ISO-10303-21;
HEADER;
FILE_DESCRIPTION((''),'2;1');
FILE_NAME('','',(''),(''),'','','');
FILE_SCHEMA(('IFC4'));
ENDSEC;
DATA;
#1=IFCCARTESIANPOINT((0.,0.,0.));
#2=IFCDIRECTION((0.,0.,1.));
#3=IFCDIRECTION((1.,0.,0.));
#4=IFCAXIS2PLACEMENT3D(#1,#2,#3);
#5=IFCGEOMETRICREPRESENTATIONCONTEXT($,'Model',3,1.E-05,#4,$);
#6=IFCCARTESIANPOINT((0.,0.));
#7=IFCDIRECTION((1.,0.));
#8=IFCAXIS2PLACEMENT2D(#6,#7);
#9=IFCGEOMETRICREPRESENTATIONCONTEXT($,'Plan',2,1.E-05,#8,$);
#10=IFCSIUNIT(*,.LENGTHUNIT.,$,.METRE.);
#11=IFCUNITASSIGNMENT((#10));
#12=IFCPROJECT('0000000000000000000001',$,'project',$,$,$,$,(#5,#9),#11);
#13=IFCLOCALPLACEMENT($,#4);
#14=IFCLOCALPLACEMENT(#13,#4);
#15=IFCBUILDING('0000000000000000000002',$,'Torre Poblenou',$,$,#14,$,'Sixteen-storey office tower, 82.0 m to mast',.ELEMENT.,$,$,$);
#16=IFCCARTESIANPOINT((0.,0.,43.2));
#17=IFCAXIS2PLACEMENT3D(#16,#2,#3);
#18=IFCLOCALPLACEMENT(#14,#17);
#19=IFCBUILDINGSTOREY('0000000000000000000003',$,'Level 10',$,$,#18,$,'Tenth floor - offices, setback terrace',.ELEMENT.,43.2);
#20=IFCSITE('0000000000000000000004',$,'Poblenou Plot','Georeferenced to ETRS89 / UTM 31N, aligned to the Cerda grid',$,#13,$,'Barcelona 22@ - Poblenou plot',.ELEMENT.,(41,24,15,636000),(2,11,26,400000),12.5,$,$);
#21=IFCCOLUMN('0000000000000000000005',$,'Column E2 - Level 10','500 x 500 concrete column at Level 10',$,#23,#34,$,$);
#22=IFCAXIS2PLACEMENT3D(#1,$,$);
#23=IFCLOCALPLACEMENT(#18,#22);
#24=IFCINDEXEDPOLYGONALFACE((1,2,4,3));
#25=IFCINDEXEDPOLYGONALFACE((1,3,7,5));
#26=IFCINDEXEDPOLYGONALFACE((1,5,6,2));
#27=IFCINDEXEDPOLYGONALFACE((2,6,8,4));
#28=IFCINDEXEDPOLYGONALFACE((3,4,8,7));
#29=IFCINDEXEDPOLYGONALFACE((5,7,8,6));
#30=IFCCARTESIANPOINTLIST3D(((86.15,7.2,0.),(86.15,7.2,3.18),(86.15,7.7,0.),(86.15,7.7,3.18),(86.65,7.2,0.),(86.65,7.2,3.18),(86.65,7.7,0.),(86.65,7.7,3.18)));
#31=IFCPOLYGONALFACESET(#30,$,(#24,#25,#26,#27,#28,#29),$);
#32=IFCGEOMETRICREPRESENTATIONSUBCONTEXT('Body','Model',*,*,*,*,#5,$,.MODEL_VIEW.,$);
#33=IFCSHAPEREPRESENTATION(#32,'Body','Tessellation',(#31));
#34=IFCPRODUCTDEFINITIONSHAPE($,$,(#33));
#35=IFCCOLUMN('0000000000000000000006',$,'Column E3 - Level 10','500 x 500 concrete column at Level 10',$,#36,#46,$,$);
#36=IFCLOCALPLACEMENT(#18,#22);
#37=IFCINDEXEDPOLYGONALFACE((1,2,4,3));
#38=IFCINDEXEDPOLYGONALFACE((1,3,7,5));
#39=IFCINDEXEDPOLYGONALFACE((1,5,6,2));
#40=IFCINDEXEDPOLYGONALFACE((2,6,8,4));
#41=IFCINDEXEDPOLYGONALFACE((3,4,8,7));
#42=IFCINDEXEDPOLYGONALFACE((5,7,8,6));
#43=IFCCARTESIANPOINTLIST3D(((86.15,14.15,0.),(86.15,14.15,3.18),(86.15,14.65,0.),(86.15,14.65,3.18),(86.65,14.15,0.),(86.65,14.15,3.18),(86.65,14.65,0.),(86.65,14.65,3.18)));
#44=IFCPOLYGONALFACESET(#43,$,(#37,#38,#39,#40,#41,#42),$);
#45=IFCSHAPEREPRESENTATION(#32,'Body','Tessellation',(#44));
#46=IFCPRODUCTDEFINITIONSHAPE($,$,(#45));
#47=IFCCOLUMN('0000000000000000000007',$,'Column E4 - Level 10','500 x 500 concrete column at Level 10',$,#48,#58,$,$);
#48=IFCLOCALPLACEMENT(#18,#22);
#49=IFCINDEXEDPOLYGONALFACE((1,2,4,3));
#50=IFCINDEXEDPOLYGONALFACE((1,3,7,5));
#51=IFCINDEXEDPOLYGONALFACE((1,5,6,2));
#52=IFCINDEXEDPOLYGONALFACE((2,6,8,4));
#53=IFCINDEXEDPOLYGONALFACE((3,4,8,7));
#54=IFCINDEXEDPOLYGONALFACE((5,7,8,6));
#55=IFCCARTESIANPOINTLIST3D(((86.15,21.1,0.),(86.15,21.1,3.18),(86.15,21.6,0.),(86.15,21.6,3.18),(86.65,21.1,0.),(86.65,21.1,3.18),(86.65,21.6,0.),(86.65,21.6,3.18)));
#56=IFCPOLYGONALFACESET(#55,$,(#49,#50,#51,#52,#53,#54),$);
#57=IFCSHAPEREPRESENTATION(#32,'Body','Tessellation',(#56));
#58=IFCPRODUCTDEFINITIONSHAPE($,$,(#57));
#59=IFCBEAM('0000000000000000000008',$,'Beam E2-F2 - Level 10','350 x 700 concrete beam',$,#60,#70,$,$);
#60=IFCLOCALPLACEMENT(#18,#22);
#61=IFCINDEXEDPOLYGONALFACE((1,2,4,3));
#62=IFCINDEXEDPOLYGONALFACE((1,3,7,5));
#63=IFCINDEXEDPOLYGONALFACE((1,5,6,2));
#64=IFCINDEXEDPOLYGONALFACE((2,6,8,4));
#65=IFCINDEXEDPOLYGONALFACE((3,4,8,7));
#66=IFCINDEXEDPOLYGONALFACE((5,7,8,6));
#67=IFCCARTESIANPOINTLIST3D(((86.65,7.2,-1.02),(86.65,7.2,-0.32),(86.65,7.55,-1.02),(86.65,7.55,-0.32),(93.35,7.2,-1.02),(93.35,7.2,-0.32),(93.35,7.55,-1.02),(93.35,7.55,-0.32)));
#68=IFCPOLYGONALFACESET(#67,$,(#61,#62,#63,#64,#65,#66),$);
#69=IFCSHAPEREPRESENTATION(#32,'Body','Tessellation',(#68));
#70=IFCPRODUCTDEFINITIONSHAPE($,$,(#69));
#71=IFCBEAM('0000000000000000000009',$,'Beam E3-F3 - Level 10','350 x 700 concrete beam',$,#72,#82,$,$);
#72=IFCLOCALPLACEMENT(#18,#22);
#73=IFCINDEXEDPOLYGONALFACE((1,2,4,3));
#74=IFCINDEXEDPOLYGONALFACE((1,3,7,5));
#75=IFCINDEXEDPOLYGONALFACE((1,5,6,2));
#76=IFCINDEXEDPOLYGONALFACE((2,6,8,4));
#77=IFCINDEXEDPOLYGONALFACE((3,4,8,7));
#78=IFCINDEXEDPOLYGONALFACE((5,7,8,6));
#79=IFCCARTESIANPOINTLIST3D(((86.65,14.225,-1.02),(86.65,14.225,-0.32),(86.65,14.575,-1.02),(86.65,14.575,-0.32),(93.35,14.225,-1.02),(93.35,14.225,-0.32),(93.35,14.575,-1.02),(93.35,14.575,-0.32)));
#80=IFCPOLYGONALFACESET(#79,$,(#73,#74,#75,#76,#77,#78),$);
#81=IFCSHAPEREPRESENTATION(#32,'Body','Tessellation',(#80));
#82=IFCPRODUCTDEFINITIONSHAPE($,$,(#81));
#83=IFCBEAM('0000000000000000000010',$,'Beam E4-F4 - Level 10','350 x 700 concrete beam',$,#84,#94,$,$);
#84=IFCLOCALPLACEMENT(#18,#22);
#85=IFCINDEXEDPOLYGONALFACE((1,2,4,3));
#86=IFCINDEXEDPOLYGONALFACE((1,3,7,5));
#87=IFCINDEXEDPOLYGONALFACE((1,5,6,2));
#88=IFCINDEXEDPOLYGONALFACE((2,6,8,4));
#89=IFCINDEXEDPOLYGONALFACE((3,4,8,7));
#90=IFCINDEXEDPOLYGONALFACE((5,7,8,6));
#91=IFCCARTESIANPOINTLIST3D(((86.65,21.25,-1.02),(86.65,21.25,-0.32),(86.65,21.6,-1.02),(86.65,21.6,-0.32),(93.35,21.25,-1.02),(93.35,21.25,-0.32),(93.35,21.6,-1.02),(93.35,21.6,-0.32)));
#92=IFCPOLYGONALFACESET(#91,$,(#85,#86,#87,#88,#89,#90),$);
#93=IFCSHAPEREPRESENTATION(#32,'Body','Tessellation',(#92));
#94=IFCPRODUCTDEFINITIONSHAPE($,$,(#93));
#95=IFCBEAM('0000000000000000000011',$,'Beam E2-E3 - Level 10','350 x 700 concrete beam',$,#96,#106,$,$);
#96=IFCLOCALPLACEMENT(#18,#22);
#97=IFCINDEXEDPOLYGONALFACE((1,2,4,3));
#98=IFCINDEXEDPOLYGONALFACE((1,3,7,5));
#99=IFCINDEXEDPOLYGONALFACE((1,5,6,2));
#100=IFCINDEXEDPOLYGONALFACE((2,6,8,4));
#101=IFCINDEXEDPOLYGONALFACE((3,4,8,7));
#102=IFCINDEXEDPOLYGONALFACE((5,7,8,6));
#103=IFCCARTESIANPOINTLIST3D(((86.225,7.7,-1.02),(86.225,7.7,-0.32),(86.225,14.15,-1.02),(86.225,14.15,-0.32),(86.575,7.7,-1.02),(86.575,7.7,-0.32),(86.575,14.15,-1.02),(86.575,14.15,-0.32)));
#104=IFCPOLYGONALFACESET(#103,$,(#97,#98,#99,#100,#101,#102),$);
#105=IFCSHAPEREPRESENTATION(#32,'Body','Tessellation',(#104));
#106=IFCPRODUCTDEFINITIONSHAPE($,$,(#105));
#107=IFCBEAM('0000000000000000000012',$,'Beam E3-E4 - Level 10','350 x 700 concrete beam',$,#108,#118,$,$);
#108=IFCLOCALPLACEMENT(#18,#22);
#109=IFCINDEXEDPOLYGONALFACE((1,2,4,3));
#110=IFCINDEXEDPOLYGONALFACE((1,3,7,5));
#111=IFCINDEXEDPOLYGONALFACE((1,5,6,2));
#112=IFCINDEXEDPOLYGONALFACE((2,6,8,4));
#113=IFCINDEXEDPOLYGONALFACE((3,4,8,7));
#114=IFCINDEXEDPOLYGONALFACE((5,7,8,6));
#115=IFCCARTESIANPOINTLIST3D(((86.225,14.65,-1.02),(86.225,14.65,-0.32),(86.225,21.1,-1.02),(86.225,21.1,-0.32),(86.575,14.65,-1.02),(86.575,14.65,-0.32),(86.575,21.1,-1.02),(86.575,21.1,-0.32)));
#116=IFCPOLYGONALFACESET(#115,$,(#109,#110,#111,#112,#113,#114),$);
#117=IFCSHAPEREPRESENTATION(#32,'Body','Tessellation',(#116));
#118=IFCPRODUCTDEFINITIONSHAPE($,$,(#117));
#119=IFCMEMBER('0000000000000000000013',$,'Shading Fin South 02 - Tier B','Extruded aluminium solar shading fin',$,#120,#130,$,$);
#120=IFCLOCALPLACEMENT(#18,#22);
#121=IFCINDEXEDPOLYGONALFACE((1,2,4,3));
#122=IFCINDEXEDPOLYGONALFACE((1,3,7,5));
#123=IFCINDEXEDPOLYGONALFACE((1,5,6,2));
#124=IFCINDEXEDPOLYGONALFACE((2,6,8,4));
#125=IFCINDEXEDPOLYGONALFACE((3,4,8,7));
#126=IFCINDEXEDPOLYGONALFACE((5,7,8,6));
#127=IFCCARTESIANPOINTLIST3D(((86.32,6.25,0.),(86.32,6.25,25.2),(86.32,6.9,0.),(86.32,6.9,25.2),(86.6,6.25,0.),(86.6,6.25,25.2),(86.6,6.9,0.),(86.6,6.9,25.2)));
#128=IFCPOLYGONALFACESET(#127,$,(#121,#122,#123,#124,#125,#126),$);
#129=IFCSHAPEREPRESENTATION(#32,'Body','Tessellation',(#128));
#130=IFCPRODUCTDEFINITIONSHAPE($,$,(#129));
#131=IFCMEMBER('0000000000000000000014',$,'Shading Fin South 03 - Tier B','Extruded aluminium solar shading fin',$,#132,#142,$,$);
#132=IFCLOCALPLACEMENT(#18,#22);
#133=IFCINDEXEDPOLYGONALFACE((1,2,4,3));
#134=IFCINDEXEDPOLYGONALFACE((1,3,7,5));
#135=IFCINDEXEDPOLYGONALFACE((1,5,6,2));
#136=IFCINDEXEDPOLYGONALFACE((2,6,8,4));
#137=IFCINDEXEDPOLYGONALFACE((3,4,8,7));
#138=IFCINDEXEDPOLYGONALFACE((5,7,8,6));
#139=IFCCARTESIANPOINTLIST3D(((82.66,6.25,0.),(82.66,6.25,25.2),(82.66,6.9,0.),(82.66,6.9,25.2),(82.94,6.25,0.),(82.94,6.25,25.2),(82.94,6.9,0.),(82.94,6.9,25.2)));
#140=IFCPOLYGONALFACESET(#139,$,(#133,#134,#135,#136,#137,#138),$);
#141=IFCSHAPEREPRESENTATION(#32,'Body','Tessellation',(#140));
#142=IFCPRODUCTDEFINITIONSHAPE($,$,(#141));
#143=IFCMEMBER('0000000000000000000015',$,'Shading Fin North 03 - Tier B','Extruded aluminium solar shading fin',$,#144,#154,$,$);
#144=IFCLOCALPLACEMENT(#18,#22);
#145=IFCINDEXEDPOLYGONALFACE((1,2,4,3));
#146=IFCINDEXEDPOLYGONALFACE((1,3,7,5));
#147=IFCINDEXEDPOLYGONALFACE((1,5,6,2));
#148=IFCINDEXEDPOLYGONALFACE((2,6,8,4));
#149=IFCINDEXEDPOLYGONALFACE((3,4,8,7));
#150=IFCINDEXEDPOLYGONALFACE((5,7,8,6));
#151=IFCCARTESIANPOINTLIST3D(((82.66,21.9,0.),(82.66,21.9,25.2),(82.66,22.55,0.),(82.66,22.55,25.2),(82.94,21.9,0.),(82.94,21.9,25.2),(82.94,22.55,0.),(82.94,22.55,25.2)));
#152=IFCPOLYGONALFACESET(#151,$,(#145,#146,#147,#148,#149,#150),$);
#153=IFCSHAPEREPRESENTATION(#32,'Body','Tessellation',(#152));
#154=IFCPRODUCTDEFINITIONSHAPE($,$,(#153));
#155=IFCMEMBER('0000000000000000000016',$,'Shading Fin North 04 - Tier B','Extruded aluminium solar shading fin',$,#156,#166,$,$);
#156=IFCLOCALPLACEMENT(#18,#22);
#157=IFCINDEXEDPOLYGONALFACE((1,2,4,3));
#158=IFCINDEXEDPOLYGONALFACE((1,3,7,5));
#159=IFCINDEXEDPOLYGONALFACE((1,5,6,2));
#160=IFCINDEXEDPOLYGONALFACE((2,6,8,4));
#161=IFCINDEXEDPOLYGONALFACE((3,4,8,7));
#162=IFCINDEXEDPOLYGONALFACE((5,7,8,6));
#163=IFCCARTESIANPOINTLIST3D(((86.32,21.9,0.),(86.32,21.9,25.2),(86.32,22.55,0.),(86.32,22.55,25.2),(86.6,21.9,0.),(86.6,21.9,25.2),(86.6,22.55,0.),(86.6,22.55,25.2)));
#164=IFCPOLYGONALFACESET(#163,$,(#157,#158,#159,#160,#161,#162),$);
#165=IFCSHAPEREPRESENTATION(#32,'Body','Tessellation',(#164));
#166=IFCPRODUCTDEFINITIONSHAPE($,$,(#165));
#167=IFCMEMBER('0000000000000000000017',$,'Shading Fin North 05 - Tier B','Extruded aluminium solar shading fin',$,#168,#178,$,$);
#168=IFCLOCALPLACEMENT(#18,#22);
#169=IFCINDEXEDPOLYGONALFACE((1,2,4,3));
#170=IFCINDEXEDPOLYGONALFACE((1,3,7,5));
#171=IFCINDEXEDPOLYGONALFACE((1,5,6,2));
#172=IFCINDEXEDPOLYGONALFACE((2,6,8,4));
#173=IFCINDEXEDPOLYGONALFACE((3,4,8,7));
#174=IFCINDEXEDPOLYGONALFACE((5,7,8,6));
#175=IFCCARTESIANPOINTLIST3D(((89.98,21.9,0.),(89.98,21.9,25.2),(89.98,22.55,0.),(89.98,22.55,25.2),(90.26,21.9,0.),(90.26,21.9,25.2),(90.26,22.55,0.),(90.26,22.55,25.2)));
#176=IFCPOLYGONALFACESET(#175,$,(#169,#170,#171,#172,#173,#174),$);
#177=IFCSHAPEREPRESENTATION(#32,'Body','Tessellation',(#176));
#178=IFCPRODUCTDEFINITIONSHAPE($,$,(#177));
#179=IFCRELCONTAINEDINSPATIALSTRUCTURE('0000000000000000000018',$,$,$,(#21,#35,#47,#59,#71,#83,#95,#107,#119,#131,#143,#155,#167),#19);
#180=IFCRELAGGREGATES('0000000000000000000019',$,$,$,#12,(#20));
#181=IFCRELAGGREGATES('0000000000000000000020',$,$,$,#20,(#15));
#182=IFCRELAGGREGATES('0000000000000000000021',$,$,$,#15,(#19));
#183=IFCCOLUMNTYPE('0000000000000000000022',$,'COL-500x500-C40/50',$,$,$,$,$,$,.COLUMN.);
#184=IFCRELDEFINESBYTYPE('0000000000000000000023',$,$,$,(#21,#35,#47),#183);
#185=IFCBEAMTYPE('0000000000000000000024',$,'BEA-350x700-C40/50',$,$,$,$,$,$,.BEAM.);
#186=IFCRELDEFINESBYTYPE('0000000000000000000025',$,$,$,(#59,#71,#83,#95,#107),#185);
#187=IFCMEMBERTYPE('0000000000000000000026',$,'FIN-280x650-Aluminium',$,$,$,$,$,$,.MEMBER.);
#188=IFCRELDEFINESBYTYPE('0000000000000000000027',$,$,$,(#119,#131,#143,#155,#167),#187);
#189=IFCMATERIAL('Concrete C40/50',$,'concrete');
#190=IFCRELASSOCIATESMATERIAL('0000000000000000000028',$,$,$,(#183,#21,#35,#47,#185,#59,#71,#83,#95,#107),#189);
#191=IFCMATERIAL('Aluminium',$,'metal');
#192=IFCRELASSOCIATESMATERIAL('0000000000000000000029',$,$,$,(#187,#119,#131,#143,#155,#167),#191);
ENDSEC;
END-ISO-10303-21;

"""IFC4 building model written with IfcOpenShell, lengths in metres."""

from ifc_helpers import new_model, si_unit, frame, origin_with_axes, origin_2d_with_axis, place, context, subcontext, project, spatial, line, indexed_curve, rectangle, outline, extrude, material, material_profile, profile_set, profile_usage, type_object, element, save


model = new_model("IFC4")

# Units and contexts
model_context = context("Model", 3, precision=1e-05, world=origin_with_axes())
plan_context = context("Plan", 2, precision=1e-05, world=origin_2d_with_axis())
body_context = subcontext(model_context, "Body", "Model", "MODEL_VIEW")
ifc_project = project(units=[si_unit("LENGTHUNIT", "METRE")], contexts=[model_context, plan_context])

# Site, building, storey
site_placement = place(None, origin_with_axes())
site = spatial("IfcSite", under=ifc_project, at=site_placement, Name="Poblenou Plot", Description="Georeferenced to ETRS89 / UTM 31N, aligned to the Cerda grid", LongName="Barcelona 22@ - Poblenou plot", CompositionType="ELEMENT", RefLatitude=(41, 24, 15, 636000), RefLongitude=(2, 11, 26, 400000), RefElevation=12.5)
building_placement = place(site_placement, origin_with_axes())
building = spatial("IfcBuilding", under=site, at=building_placement, Name="Torre Poblenou", LongName="Sixteen-storey office tower, 82.0 m to mast", CompositionType="ELEMENT")
storey_placement = place(building_placement, frame((0.0, 0.0, 43.2), z_axis=(0.0, 0.0, 1.0), x_axis=(1.0, 0.0, 0.0)))
storey = spatial("IfcBuildingStorey", under=building, at=storey_placement, Name="Level 10", LongName="Tenth floor - offices, setback terrace", CompositionType="ELEMENT", Elevation=43.2)

# Columns
ifc_material_1 = material(Name="Concrete C40/50", Category="concrete")
ifc_material_profile_1 = material_profile(ifc_material_1, rectangle(XDim=0.5, YDim=0.5))
ifc_profile_set_1 = profile_set([ifc_material_profile_1], Name="COL-500x500-C40/50")
ifc_profile_usage_1 = profile_usage(ifc_profile_set_1)
column_type = type_object("IfcColumnType", Name="COL-500x500-C40/50", PredefinedType="COLUMN", material=ifc_profile_set_1)
column_1_placement = place(storey_placement, frame((86.15, 7.2, 0.0), z_axis=(0.0, 0.0, 1.0), x_axis=(1.0, 0.0, 0.0)))
element("IfcColumn", 1, at=column_1_placement, inside=storey, type_object=column_type, material=ifc_profile_usage_1, Name="Column E2 - Level 10", Description="500 x 500 concrete column at Level 10", context=body_context, shape_type="SweptSolid", body=[
    extrude(outline(indexed_curve([(0.0, 0.0), (0.5, 0.0), (0.5, 0.5), (0.0, 0.5)], segments=[line(1, 2, 3, 4, 1)])), origin_with_axes(), (0.0, 0.0, 1.0), 3.18),
])
ifc_profile_usage_2 = profile_usage(ifc_profile_set_1)
column_2_placement = place(storey_placement, frame((86.15, 14.15, 0.0), z_axis=(0.0, 0.0, 1.0), x_axis=(1.0, 0.0, 0.0)))
element("IfcColumn", 2, at=column_2_placement, inside=storey, type_object=column_type, material=ifc_profile_usage_2, Name="Column E3 - Level 10", Description="500 x 500 concrete column at Level 10", context=body_context, shape_type="SweptSolid", body=[
    extrude(outline(indexed_curve([(0.0, 0.0), (0.5, 0.0), (0.5, 0.5), (0.0, 0.5)], segments=[line(1, 2, 3, 4, 1)])), origin_with_axes(), (0.0, 0.0, 1.0), 3.18),
])
ifc_profile_usage_3 = profile_usage(ifc_profile_set_1)
column_3_placement = place(storey_placement, frame((86.15, 21.1, 0.0), z_axis=(0.0, 0.0, 1.0), x_axis=(1.0, 0.0, 0.0)))
element("IfcColumn", 3, at=column_3_placement, inside=storey, type_object=column_type, material=ifc_profile_usage_3, Name="Column E4 - Level 10", Description="500 x 500 concrete column at Level 10", context=body_context, shape_type="SweptSolid", body=[
    extrude(outline(indexed_curve([(0.0, 0.0), (0.5, 0.0), (0.5, 0.5), (0.0, 0.5)], segments=[line(1, 2, 3, 4, 1)])), origin_with_axes(), (0.0, 0.0, 1.0), 3.18),
])

# Beams
ifc_material_profile_2 = material_profile(ifc_material_1, rectangle(XDim=0.35, YDim=0.7))
ifc_profile_set_2 = profile_set([ifc_material_profile_2], Name="BEA-350x700-C40/50")
ifc_profile_usage_4 = profile_usage(ifc_profile_set_2)
beam_type = type_object("IfcBeamType", Name="BEA-350x700-C40/50", PredefinedType="BEAM", material=ifc_profile_set_2)
beam_1_placement = place(storey_placement, frame((86.65, 7.2, -1.02), z_axis=(0.0, 0.0, 1.0), x_axis=(1.0, 0.0, 0.0)))
element("IfcBeam", 4, at=beam_1_placement, inside=storey, type_object=beam_type, material=ifc_profile_usage_4, Name="Beam E2-F2 - Level 10", Description="350 x 700 concrete beam", context=body_context, shape_type="SweptSolid", body=[
    extrude(outline(indexed_curve([(0.0, 0.0), (6.7, 0.0), (6.7, 0.35), (0.0, 0.35)], segments=[line(1, 2, 3, 4, 1)])), origin_with_axes(), (0.0, 0.0, 1.0), 0.7),
])
ifc_profile_usage_5 = profile_usage(ifc_profile_set_2)
beam_2_placement = place(storey_placement, frame((86.65, 14.225, -1.02), z_axis=(0.0, 0.0, 1.0), x_axis=(1.0, 0.0, 0.0)))
element("IfcBeam", 5, at=beam_2_placement, inside=storey, type_object=beam_type, material=ifc_profile_usage_5, Name="Beam E3-F3 - Level 10", Description="350 x 700 concrete beam", context=body_context, shape_type="SweptSolid", body=[
    extrude(outline(indexed_curve([(0.0, 0.0), (6.7, 0.0), (6.7, 0.35), (0.0, 0.35)], segments=[line(1, 2, 3, 4, 1)])), origin_with_axes(), (0.0, 0.0, 1.0), 0.7),
])
ifc_profile_usage_6 = profile_usage(ifc_profile_set_2)
beam_3_placement = place(storey_placement, frame((86.65, 21.25, -1.02), z_axis=(0.0, 0.0, 1.0), x_axis=(1.0, 0.0, 0.0)))
element("IfcBeam", 6, at=beam_3_placement, inside=storey, type_object=beam_type, material=ifc_profile_usage_6, Name="Beam E4-F4 - Level 10", Description="350 x 700 concrete beam", context=body_context, shape_type="SweptSolid", body=[
    extrude(outline(indexed_curve([(0.0, 0.0), (6.7, 0.0), (6.7, 0.35), (0.0, 0.35)], segments=[line(1, 2, 3, 4, 1)])), origin_with_axes(), (0.0, 0.0, 1.0), 0.7),
])
ifc_profile_usage_7 = profile_usage(ifc_profile_set_2)
beam_4_placement = place(storey_placement, frame((86.575, 7.7, -1.02), z_axis=(0.0, 0.0, 1.0), x_axis=(0.0, 1.0, 0.0)))
element("IfcBeam", 7, at=beam_4_placement, inside=storey, type_object=beam_type, material=ifc_profile_usage_7, Name="Beam E2-E3 - Level 10", Description="350 x 700 concrete beam", context=body_context, shape_type="SweptSolid", body=[
    extrude(outline(indexed_curve([(0.0, 0.0), (6.45, 0.0), (6.45, 0.35), (0.0, 0.35)], segments=[line(1, 2, 3, 4, 1)])), origin_with_axes(), (0.0, 0.0, 1.0), 0.7),
])
ifc_profile_usage_8 = profile_usage(ifc_profile_set_2)
beam_5_placement = place(storey_placement, frame((86.575, 14.65, -1.02), z_axis=(0.0, 0.0, 1.0), x_axis=(0.0, 1.0, 0.0)))
element("IfcBeam", 8, at=beam_5_placement, inside=storey, type_object=beam_type, material=ifc_profile_usage_8, Name="Beam E3-E4 - Level 10", Description="350 x 700 concrete beam", context=body_context, shape_type="SweptSolid", body=[
    extrude(outline(indexed_curve([(0.0, 0.0), (6.45, 0.0), (6.45, 0.35), (0.0, 0.35)], segments=[line(1, 2, 3, 4, 1)])), origin_with_axes(), (0.0, 0.0, 1.0), 0.7),
])

# Members
ifc_material_2 = material(Name="Aluminium", Category="metal")
ifc_material_profile_3 = material_profile(ifc_material_2, rectangle(XDim=0.28, YDim=0.65))
ifc_profile_set_3 = profile_set([ifc_material_profile_3], Name="FIN-280x650-Aluminium")
ifc_profile_usage_9 = profile_usage(ifc_profile_set_3)
member_type = type_object("IfcMemberType", Name="FIN-280x650-Aluminium", PredefinedType="MEMBER", material=ifc_profile_set_3)
member_1_placement = place(storey_placement, frame((86.6, 6.9, 0.0), z_axis=(0.0, 0.0, 1.0), x_axis=(-1.0, 0.0, 0.0)))
element("IfcMember", 9, at=member_1_placement, inside=storey, type_object=member_type, material=ifc_profile_usage_9, Name="Shading Fin South 02 - Tier B", Description="Extruded aluminium solar shading fin", context=body_context, shape_type="SweptSolid", body=[
    extrude(outline(indexed_curve([(0.0, 0.0), (0.28, 0.0), (0.28, 0.65), (0.0, 0.65)], segments=[line(1, 2, 3, 4, 1)])), origin_with_axes(), (0.0, 0.0, 1.0), 25.2),
])
ifc_profile_usage_10 = profile_usage(ifc_profile_set_3)
member_2_placement = place(storey_placement, frame((82.94, 6.9, 0.0), z_axis=(0.0, 0.0, 1.0), x_axis=(-1.0, 0.0, 0.0)))
element("IfcMember", 10, at=member_2_placement, inside=storey, type_object=member_type, material=ifc_profile_usage_10, Name="Shading Fin South 03 - Tier B", Description="Extruded aluminium solar shading fin", context=body_context, shape_type="SweptSolid", body=[
    extrude(outline(indexed_curve([(0.0, 0.0), (0.28, 0.0), (0.28, 0.65), (0.0, 0.65)], segments=[line(1, 2, 3, 4, 1)])), origin_with_axes(), (0.0, 0.0, 1.0), 25.2),
])
ifc_profile_usage_11 = profile_usage(ifc_profile_set_3)
member_3_placement = place(storey_placement, frame((82.66, 21.9, 0.0), z_axis=(0.0, 0.0, 1.0), x_axis=(1.0, 0.0, 0.0)))
element("IfcMember", 11, at=member_3_placement, inside=storey, type_object=member_type, material=ifc_profile_usage_11, Name="Shading Fin North 03 - Tier B", Description="Extruded aluminium solar shading fin", context=body_context, shape_type="SweptSolid", body=[
    extrude(outline(indexed_curve([(0.0, 0.0), (0.28, 0.0), (0.28, 0.65), (0.0, 0.65)], segments=[line(1, 2, 3, 4, 1)])), origin_with_axes(), (0.0, 0.0, 1.0), 25.2),
])
ifc_profile_usage_12 = profile_usage(ifc_profile_set_3)
member_4_placement = place(storey_placement, frame((86.32, 21.9, 0.0), z_axis=(0.0, 0.0, 1.0), x_axis=(1.0, 0.0, 0.0)))
element("IfcMember", 12, at=member_4_placement, inside=storey, type_object=member_type, material=ifc_profile_usage_12, Name="Shading Fin North 04 - Tier B", Description="Extruded aluminium solar shading fin", context=body_context, shape_type="SweptSolid", body=[
    extrude(outline(indexed_curve([(0.0, 0.0), (0.28, 0.0), (0.28, 0.65), (0.0, 0.65)], segments=[line(1, 2, 3, 4, 1)])), origin_with_axes(), (0.0, 0.0, 1.0), 25.2),
])
ifc_profile_usage_13 = profile_usage(ifc_profile_set_3)
member_5_placement = place(storey_placement, frame((89.98, 21.9, 0.0), z_axis=(0.0, 0.0, 1.0), x_axis=(1.0, 0.0, 0.0)))
element("IfcMember", 13, at=member_5_placement, inside=storey, type_object=member_type, material=ifc_profile_usage_13, Name="Shading Fin North 05 - Tier B", Description="Extruded aluminium solar shading fin", context=body_context, shape_type="SweptSolid", body=[
    extrude(outline(indexed_curve([(0.0, 0.0), (0.28, 0.0), (0.28, 0.65), (0.0, 0.65)], segments=[line(1, 2, 3, 4, 1)])), origin_with_axes(), (0.0, 0.0, 1.0), 25.2),
])

save(model, "model.ifc")
